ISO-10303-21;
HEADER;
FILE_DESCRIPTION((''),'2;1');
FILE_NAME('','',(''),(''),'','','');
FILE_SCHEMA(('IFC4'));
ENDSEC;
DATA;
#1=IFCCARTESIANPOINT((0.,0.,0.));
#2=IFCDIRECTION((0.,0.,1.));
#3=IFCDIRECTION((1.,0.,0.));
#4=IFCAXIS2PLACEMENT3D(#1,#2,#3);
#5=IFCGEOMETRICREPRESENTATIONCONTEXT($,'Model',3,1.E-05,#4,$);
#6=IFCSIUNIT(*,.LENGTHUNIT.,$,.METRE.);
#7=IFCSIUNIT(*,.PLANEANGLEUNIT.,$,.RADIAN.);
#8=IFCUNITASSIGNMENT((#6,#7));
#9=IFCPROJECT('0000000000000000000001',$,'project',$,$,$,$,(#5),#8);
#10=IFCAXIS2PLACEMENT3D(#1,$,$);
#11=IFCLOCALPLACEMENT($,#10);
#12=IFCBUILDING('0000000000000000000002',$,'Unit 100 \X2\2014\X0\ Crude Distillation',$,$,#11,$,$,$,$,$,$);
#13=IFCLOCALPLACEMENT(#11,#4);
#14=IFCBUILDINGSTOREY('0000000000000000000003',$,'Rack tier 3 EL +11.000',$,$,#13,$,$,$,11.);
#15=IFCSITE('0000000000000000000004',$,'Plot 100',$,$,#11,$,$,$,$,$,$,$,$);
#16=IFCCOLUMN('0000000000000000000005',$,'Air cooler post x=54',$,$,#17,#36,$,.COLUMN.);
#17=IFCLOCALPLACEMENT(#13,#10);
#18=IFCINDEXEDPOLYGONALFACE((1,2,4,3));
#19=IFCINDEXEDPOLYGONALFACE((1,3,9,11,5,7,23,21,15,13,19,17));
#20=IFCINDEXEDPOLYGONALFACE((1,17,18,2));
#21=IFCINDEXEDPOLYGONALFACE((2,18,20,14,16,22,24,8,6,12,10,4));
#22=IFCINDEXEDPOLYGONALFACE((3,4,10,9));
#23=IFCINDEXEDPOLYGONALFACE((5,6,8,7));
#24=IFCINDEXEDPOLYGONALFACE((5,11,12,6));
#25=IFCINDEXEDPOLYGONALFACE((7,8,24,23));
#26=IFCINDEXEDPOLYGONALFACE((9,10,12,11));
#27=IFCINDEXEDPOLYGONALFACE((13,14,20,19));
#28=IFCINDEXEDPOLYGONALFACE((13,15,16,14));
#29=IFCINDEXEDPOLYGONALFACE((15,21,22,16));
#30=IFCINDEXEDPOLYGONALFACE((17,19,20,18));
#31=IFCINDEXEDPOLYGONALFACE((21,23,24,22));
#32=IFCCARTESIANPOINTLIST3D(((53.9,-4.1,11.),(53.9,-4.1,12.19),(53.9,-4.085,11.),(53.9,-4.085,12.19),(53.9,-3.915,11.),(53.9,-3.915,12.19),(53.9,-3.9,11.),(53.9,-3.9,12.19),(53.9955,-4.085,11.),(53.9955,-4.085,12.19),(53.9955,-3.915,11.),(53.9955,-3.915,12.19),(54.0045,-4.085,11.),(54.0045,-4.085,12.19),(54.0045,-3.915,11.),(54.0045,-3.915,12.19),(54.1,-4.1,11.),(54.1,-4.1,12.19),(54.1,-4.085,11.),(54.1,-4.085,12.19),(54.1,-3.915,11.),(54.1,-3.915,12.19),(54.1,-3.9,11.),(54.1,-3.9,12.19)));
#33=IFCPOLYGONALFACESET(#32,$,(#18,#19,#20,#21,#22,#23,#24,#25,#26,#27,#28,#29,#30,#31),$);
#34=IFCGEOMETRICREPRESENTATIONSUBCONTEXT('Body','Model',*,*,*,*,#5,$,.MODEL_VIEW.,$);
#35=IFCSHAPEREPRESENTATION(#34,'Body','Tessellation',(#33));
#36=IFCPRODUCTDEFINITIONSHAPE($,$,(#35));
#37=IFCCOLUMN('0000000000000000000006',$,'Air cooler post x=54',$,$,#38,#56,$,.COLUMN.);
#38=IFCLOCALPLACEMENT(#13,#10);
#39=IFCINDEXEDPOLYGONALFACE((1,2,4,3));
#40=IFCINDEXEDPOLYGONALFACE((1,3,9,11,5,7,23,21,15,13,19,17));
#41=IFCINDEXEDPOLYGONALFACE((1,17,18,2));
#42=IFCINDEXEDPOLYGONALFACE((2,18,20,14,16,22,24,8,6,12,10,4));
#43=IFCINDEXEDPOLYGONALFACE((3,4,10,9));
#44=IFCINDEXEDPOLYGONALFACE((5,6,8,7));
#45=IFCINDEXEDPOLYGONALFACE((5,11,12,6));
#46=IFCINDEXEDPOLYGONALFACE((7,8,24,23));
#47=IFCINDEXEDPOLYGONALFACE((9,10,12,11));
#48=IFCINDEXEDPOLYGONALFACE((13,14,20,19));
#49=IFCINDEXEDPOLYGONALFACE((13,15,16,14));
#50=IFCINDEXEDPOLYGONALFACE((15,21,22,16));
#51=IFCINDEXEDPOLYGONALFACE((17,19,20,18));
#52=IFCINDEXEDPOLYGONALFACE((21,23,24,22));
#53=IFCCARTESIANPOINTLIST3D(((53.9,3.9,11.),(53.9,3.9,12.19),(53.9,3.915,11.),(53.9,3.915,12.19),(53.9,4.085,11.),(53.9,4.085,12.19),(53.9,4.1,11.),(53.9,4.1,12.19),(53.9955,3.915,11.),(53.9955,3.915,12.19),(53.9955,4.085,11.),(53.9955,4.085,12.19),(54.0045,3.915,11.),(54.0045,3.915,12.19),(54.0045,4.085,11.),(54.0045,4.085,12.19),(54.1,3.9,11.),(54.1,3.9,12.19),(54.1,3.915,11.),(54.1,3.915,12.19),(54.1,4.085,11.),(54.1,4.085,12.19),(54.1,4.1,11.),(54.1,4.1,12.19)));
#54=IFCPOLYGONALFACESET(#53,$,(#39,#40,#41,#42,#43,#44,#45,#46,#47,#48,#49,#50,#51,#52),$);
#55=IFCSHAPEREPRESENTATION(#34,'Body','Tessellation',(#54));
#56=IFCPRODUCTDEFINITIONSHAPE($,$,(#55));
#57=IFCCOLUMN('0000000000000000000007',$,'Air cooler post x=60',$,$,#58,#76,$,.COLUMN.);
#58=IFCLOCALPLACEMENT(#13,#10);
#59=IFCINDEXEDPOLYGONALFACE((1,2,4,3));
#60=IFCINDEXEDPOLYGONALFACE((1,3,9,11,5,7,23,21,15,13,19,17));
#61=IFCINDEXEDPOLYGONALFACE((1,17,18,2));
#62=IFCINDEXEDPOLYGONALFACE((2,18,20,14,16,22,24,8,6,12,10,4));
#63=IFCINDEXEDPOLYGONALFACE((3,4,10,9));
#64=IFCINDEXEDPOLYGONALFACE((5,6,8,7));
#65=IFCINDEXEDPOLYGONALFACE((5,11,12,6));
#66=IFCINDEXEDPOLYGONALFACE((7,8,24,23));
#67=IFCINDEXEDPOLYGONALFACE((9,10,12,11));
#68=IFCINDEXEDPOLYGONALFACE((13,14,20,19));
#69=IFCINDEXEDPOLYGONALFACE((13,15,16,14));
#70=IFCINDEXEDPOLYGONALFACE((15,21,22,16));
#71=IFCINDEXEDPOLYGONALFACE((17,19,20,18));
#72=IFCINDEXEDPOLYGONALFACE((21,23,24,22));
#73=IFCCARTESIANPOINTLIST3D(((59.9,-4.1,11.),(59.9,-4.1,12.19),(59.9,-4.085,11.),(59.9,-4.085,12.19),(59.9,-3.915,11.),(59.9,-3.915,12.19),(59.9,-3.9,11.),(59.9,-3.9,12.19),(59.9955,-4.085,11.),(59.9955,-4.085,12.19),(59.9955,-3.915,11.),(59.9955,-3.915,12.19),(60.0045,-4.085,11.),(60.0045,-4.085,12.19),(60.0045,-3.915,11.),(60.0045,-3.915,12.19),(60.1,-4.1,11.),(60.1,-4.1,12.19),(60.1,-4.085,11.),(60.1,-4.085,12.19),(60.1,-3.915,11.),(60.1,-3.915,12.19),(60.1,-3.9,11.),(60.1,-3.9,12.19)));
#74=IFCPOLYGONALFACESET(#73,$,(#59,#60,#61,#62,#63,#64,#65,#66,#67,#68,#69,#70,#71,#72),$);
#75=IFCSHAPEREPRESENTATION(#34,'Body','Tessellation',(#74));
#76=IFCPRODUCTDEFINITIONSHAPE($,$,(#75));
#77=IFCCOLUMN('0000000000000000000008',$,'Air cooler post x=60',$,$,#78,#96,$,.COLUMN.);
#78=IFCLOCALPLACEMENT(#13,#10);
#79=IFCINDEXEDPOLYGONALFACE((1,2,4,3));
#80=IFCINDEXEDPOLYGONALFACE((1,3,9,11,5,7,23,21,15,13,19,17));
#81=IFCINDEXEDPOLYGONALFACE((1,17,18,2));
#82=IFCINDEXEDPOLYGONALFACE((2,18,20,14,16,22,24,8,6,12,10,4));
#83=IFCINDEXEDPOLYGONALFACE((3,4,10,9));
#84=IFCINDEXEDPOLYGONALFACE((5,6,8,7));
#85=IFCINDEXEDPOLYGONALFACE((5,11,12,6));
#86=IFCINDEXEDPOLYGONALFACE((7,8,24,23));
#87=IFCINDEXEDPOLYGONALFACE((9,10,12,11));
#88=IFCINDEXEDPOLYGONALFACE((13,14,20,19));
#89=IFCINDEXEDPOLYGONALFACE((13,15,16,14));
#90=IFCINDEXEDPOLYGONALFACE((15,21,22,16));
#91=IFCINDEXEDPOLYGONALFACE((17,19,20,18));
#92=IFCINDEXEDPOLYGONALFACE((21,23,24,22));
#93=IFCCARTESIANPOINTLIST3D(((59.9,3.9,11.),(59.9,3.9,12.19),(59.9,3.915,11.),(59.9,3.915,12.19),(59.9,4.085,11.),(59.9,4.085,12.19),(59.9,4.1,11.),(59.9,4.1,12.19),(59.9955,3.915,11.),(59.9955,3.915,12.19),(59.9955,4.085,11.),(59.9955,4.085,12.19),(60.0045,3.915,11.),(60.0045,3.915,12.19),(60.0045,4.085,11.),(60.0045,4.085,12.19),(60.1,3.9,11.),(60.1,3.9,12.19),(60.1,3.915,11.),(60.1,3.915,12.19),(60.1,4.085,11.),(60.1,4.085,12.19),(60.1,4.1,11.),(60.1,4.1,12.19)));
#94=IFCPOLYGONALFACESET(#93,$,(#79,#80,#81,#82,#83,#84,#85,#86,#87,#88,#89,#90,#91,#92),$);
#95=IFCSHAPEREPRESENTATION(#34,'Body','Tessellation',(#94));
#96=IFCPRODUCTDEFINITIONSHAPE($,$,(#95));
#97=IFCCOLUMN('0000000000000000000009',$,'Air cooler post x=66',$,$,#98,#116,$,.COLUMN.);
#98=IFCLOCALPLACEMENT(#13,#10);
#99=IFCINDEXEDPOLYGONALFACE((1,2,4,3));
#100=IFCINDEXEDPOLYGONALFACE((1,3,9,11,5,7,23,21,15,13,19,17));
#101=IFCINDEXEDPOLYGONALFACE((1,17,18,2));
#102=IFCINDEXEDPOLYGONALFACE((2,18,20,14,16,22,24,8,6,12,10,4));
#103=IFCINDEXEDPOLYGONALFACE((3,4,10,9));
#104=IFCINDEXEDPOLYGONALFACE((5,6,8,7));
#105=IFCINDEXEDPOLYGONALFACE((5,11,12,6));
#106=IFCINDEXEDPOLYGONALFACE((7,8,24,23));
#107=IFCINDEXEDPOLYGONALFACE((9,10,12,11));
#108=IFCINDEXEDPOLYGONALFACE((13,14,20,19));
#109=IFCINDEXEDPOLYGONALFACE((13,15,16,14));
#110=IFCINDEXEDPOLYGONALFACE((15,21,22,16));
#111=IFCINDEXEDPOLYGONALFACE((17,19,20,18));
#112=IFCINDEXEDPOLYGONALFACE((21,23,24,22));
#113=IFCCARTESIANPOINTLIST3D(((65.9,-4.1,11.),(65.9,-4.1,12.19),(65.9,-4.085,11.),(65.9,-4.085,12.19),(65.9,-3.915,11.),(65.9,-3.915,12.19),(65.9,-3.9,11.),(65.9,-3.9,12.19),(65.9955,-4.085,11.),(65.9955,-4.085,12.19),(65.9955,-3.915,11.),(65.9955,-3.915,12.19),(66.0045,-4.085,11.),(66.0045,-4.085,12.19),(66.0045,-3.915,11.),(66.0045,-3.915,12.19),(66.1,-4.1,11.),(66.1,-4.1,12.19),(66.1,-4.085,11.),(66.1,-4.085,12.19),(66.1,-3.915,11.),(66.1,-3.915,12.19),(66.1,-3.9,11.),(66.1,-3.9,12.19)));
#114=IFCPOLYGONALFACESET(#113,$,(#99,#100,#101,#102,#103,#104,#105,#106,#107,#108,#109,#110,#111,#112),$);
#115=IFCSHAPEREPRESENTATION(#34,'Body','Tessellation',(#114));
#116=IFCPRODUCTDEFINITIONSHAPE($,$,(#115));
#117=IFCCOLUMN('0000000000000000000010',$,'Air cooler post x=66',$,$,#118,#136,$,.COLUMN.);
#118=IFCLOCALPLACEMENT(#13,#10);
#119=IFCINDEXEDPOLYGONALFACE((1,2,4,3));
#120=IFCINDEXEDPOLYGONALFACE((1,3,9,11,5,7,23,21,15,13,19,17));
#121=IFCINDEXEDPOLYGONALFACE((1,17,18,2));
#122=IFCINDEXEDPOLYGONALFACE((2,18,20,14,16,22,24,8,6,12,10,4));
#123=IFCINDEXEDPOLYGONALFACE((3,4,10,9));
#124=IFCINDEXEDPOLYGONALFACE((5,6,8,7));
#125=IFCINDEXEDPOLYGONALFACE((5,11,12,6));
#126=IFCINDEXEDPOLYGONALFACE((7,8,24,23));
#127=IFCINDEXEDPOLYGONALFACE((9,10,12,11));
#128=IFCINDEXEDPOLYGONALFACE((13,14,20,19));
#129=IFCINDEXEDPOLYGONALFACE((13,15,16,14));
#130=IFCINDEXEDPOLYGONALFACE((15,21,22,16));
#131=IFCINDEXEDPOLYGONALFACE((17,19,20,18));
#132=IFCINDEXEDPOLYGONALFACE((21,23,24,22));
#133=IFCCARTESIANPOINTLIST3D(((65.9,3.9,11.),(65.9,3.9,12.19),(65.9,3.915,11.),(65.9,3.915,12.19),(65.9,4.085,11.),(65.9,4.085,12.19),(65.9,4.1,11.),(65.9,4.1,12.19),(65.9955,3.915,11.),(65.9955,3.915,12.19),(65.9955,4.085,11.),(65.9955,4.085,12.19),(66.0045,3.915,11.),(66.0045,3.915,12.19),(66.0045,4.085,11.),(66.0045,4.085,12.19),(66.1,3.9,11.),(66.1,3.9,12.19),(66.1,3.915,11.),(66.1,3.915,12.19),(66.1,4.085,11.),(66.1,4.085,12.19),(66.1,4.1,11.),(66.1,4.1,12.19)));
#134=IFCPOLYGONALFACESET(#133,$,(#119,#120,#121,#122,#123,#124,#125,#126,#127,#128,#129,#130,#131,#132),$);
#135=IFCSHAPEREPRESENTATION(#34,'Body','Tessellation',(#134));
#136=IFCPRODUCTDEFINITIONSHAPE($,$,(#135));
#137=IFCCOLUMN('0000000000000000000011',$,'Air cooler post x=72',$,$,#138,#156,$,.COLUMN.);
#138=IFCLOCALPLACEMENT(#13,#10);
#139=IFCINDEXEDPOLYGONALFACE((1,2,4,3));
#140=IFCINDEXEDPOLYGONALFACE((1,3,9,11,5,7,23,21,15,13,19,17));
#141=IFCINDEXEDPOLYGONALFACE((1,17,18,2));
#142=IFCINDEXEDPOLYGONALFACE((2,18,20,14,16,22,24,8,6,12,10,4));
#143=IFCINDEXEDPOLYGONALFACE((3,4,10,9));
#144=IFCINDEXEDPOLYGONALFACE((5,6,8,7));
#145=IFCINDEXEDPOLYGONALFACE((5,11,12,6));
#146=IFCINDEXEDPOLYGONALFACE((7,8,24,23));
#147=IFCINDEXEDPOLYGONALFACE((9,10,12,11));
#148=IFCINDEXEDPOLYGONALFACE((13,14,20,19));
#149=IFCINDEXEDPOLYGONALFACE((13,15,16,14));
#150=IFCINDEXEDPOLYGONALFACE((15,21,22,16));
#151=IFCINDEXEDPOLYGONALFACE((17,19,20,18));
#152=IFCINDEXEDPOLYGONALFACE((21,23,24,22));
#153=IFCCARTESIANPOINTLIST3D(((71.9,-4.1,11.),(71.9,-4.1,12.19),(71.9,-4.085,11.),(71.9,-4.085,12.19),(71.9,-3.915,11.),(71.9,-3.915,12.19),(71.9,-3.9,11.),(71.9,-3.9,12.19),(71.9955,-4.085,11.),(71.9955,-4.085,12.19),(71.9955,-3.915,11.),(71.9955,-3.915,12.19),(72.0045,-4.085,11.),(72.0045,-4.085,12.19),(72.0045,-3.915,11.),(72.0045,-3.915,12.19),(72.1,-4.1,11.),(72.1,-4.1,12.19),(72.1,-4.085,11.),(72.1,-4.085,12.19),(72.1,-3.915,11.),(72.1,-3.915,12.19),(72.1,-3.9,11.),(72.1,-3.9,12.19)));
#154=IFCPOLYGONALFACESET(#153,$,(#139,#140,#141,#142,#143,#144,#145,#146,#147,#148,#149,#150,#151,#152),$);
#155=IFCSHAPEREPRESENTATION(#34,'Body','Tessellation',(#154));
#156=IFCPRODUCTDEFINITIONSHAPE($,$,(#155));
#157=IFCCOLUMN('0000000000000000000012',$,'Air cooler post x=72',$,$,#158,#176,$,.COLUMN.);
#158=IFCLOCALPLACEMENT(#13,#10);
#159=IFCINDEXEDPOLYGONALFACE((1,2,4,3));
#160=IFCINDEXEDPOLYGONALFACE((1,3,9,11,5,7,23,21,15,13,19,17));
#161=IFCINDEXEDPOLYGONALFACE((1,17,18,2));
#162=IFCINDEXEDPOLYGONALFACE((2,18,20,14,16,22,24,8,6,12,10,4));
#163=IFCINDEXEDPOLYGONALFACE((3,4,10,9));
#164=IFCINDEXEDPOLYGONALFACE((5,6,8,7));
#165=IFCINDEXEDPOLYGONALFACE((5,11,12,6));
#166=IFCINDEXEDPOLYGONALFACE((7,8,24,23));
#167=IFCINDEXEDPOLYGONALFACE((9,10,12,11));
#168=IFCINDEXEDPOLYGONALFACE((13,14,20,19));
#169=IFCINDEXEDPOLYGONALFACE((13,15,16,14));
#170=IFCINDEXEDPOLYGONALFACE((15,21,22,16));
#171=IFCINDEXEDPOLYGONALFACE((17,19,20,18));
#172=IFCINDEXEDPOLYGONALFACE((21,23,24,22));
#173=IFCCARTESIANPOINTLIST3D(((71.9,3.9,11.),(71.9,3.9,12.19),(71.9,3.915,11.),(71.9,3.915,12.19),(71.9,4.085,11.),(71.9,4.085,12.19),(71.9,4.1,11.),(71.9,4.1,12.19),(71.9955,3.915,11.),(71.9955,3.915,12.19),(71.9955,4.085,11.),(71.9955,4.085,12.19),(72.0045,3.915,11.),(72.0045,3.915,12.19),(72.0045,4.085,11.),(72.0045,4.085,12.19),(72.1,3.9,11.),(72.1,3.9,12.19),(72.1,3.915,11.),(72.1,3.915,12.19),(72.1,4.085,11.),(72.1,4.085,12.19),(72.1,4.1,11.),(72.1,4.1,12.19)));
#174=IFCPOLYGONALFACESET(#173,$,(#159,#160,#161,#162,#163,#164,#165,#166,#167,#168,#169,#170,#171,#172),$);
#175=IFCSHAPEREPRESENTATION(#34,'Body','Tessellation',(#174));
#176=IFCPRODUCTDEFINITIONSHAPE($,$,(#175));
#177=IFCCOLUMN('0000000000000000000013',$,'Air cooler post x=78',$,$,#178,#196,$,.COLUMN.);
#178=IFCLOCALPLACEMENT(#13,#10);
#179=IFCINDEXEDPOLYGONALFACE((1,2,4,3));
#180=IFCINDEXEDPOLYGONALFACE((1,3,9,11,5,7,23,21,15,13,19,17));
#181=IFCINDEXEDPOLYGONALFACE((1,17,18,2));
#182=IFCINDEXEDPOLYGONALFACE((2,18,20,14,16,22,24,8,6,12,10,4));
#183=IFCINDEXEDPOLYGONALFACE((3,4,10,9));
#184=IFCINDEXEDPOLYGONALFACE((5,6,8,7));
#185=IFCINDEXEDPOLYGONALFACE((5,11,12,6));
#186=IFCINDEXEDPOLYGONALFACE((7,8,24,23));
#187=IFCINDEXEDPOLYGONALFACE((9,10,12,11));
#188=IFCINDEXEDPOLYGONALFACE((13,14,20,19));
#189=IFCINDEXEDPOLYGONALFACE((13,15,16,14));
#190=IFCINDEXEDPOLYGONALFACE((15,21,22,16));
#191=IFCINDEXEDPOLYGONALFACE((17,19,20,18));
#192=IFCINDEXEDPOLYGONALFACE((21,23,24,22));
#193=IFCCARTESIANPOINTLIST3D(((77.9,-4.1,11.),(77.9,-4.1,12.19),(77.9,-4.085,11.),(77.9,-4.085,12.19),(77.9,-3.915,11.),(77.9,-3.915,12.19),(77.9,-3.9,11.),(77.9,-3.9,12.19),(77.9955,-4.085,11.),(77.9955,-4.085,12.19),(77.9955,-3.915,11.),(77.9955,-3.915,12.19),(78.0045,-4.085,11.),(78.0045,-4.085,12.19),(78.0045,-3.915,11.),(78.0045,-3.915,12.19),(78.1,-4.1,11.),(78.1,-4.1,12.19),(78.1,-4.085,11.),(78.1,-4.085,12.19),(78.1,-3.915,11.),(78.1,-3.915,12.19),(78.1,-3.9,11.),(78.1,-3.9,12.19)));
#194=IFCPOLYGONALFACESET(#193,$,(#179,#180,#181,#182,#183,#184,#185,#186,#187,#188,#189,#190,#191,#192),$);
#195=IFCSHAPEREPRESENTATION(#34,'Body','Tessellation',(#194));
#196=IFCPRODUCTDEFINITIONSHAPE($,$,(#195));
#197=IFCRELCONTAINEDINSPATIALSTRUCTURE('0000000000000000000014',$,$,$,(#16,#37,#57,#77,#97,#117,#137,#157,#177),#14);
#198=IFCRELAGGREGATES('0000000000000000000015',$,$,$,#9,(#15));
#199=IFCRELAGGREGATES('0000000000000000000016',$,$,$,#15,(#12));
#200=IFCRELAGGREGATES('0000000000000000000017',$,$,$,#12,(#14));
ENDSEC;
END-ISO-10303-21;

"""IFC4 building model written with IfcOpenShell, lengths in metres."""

from ifc_helpers import new_model, si_unit, frame, origin, origin_with_axes, origin_2d, place, context, subcontext, project, spatial, i_section, extrude, element, save


model = new_model("IFC4")

# Units and contexts
model_context = context("Model", 3, precision=1e-05, world=origin_with_axes())
body_context = subcontext(model_context, "Body", "Model", "MODEL_VIEW")
ifc_project = project(units=[si_unit("LENGTHUNIT", "METRE"), si_unit("PLANEANGLEUNIT", "RADIAN")], contexts=[model_context])

# Site, building, storey
placement = place(None, origin())
site = spatial("IfcSite", under=ifc_project, at=placement, Name="Plot 100")
building = spatial("IfcBuilding", under=site, at=placement, Name="Unit 100 — Crude Distillation")
storey_placement = place(placement, origin_with_axes())
storey = spatial("IfcBuildingStorey", under=building, at=storey_placement, Name="Rack tier 3 EL +11.000", Elevation=11.0)

# Columns
column_1_placement = place(storey_placement, origin_with_axes())
element("IfcColumn", 1, at=column_1_placement, inside=storey, Name="Air cooler post x=54", PredefinedType="COLUMN", context=body_context, shape_type="SweptSolid", body=[
    extrude(i_section(OverallWidth=0.2, OverallDepth=0.2, WebThickness=0.009, FlangeThickness=0.015, at=origin_2d()), frame((54.0, -4.0, 11.0), z_axis=(0.0, 0.0, 1.0), x_axis=(1.0, 0.0, 0.0)), (0.0, 0.0, 1.0), 1.19),
])
column_2_placement = place(storey_placement, origin_with_axes())
element("IfcColumn", 2, at=column_2_placement, inside=storey, Name="Air cooler post x=54", PredefinedType="COLUMN", context=body_context, shape_type="SweptSolid", body=[
    extrude(i_section(OverallWidth=0.2, OverallDepth=0.2, WebThickness=0.009, FlangeThickness=0.015, at=origin_2d()), frame((54.0, 4.0, 11.0), z_axis=(0.0, 0.0, 1.0), x_axis=(1.0, 0.0, 0.0)), (0.0, 0.0, 1.0), 1.19),
])
column_3_placement = place(storey_placement, origin_with_axes())
element("IfcColumn", 3, at=column_3_placement, inside=storey, Name="Air cooler post x=60", PredefinedType="COLUMN", context=body_context, shape_type="SweptSolid", body=[
    extrude(i_section(OverallWidth=0.2, OverallDepth=0.2, WebThickness=0.009, FlangeThickness=0.015, at=origin_2d()), frame((60.0, -4.0, 11.0), z_axis=(0.0, 0.0, 1.0), x_axis=(1.0, 0.0, 0.0)), (0.0, 0.0, 1.0), 1.19),
])
column_4_placement = place(storey_placement, origin_with_axes())
element("IfcColumn", 4, at=column_4_placement, inside=storey, Name="Air cooler post x=60", PredefinedType="COLUMN", context=body_context, shape_type="SweptSolid", body=[
    extrude(i_section(OverallWidth=0.2, OverallDepth=0.2, WebThickness=0.009, FlangeThickness=0.015, at=origin_2d()), frame((60.0, 4.0, 11.0), z_axis=(0.0, 0.0, 1.0), x_axis=(1.0, 0.0, 0.0)), (0.0, 0.0, 1.0), 1.19),
])
column_5_placement = place(storey_placement, origin_with_axes())
element("IfcColumn", 5, at=column_5_placement, inside=storey, Name="Air cooler post x=66", PredefinedType="COLUMN", context=body_context, shape_type="SweptSolid", body=[
    extrude(i_section(OverallWidth=0.2, OverallDepth=0.2, WebThickness=0.009, FlangeThickness=0.015, at=origin_2d()), frame((66.0, -4.0, 11.0), z_axis=(0.0, 0.0, 1.0), x_axis=(1.0, 0.0, 0.0)), (0.0, 0.0, 1.0), 1.19),
])
column_6_placement = place(storey_placement, origin_with_axes())
element("IfcColumn", 6, at=column_6_placement, inside=storey, Name="Air cooler post x=66", PredefinedType="COLUMN", context=body_context, shape_type="SweptSolid", body=[
    extrude(i_section(OverallWidth=0.2, OverallDepth=0.2, WebThickness=0.009, FlangeThickness=0.015, at=origin_2d()), frame((66.0, 4.0, 11.0), z_axis=(0.0, 0.0, 1.0), x_axis=(1.0, 0.0, 0.0)), (0.0, 0.0, 1.0), 1.19),
])
column_7_placement = place(storey_placement, origin_with_axes())
element("IfcColumn", 7, at=column_7_placement, inside=storey, Name="Air cooler post x=72", PredefinedType="COLUMN", context=body_context, shape_type="SweptSolid", body=[
    extrude(i_section(OverallWidth=0.2, OverallDepth=0.2, WebThickness=0.009, FlangeThickness=0.015, at=origin_2d()), frame((72.0, -4.0, 11.0), z_axis=(0.0, 0.0, 1.0), x_axis=(1.0, 0.0, 0.0)), (0.0, 0.0, 1.0), 1.19),
])
column_8_placement = place(storey_placement, origin_with_axes())
element("IfcColumn", 8, at=column_8_placement, inside=storey, Name="Air cooler post x=72", PredefinedType="COLUMN", context=body_context, shape_type="SweptSolid", body=[
    extrude(i_section(OverallWidth=0.2, OverallDepth=0.2, WebThickness=0.009, FlangeThickness=0.015, at=origin_2d()), frame((72.0, 4.0, 11.0), z_axis=(0.0, 0.0, 1.0), x_axis=(1.0, 0.0, 0.0)), (0.0, 0.0, 1.0), 1.19),
])
column_9_placement = place(storey_placement, origin_with_axes())
element("IfcColumn", 9, at=column_9_placement, inside=storey, Name="Air cooler post x=78", PredefinedType="COLUMN", context=body_context, shape_type="SweptSolid", body=[
    extrude(i_section(OverallWidth=0.2, OverallDepth=0.2, WebThickness=0.009, FlangeThickness=0.015, at=origin_2d()), frame((78.0, -4.0, 11.0), z_axis=(0.0, 0.0, 1.0), x_axis=(1.0, 0.0, 0.0)), (0.0, 0.0, 1.0), 1.19),
])

save(model, "model.ifc")
